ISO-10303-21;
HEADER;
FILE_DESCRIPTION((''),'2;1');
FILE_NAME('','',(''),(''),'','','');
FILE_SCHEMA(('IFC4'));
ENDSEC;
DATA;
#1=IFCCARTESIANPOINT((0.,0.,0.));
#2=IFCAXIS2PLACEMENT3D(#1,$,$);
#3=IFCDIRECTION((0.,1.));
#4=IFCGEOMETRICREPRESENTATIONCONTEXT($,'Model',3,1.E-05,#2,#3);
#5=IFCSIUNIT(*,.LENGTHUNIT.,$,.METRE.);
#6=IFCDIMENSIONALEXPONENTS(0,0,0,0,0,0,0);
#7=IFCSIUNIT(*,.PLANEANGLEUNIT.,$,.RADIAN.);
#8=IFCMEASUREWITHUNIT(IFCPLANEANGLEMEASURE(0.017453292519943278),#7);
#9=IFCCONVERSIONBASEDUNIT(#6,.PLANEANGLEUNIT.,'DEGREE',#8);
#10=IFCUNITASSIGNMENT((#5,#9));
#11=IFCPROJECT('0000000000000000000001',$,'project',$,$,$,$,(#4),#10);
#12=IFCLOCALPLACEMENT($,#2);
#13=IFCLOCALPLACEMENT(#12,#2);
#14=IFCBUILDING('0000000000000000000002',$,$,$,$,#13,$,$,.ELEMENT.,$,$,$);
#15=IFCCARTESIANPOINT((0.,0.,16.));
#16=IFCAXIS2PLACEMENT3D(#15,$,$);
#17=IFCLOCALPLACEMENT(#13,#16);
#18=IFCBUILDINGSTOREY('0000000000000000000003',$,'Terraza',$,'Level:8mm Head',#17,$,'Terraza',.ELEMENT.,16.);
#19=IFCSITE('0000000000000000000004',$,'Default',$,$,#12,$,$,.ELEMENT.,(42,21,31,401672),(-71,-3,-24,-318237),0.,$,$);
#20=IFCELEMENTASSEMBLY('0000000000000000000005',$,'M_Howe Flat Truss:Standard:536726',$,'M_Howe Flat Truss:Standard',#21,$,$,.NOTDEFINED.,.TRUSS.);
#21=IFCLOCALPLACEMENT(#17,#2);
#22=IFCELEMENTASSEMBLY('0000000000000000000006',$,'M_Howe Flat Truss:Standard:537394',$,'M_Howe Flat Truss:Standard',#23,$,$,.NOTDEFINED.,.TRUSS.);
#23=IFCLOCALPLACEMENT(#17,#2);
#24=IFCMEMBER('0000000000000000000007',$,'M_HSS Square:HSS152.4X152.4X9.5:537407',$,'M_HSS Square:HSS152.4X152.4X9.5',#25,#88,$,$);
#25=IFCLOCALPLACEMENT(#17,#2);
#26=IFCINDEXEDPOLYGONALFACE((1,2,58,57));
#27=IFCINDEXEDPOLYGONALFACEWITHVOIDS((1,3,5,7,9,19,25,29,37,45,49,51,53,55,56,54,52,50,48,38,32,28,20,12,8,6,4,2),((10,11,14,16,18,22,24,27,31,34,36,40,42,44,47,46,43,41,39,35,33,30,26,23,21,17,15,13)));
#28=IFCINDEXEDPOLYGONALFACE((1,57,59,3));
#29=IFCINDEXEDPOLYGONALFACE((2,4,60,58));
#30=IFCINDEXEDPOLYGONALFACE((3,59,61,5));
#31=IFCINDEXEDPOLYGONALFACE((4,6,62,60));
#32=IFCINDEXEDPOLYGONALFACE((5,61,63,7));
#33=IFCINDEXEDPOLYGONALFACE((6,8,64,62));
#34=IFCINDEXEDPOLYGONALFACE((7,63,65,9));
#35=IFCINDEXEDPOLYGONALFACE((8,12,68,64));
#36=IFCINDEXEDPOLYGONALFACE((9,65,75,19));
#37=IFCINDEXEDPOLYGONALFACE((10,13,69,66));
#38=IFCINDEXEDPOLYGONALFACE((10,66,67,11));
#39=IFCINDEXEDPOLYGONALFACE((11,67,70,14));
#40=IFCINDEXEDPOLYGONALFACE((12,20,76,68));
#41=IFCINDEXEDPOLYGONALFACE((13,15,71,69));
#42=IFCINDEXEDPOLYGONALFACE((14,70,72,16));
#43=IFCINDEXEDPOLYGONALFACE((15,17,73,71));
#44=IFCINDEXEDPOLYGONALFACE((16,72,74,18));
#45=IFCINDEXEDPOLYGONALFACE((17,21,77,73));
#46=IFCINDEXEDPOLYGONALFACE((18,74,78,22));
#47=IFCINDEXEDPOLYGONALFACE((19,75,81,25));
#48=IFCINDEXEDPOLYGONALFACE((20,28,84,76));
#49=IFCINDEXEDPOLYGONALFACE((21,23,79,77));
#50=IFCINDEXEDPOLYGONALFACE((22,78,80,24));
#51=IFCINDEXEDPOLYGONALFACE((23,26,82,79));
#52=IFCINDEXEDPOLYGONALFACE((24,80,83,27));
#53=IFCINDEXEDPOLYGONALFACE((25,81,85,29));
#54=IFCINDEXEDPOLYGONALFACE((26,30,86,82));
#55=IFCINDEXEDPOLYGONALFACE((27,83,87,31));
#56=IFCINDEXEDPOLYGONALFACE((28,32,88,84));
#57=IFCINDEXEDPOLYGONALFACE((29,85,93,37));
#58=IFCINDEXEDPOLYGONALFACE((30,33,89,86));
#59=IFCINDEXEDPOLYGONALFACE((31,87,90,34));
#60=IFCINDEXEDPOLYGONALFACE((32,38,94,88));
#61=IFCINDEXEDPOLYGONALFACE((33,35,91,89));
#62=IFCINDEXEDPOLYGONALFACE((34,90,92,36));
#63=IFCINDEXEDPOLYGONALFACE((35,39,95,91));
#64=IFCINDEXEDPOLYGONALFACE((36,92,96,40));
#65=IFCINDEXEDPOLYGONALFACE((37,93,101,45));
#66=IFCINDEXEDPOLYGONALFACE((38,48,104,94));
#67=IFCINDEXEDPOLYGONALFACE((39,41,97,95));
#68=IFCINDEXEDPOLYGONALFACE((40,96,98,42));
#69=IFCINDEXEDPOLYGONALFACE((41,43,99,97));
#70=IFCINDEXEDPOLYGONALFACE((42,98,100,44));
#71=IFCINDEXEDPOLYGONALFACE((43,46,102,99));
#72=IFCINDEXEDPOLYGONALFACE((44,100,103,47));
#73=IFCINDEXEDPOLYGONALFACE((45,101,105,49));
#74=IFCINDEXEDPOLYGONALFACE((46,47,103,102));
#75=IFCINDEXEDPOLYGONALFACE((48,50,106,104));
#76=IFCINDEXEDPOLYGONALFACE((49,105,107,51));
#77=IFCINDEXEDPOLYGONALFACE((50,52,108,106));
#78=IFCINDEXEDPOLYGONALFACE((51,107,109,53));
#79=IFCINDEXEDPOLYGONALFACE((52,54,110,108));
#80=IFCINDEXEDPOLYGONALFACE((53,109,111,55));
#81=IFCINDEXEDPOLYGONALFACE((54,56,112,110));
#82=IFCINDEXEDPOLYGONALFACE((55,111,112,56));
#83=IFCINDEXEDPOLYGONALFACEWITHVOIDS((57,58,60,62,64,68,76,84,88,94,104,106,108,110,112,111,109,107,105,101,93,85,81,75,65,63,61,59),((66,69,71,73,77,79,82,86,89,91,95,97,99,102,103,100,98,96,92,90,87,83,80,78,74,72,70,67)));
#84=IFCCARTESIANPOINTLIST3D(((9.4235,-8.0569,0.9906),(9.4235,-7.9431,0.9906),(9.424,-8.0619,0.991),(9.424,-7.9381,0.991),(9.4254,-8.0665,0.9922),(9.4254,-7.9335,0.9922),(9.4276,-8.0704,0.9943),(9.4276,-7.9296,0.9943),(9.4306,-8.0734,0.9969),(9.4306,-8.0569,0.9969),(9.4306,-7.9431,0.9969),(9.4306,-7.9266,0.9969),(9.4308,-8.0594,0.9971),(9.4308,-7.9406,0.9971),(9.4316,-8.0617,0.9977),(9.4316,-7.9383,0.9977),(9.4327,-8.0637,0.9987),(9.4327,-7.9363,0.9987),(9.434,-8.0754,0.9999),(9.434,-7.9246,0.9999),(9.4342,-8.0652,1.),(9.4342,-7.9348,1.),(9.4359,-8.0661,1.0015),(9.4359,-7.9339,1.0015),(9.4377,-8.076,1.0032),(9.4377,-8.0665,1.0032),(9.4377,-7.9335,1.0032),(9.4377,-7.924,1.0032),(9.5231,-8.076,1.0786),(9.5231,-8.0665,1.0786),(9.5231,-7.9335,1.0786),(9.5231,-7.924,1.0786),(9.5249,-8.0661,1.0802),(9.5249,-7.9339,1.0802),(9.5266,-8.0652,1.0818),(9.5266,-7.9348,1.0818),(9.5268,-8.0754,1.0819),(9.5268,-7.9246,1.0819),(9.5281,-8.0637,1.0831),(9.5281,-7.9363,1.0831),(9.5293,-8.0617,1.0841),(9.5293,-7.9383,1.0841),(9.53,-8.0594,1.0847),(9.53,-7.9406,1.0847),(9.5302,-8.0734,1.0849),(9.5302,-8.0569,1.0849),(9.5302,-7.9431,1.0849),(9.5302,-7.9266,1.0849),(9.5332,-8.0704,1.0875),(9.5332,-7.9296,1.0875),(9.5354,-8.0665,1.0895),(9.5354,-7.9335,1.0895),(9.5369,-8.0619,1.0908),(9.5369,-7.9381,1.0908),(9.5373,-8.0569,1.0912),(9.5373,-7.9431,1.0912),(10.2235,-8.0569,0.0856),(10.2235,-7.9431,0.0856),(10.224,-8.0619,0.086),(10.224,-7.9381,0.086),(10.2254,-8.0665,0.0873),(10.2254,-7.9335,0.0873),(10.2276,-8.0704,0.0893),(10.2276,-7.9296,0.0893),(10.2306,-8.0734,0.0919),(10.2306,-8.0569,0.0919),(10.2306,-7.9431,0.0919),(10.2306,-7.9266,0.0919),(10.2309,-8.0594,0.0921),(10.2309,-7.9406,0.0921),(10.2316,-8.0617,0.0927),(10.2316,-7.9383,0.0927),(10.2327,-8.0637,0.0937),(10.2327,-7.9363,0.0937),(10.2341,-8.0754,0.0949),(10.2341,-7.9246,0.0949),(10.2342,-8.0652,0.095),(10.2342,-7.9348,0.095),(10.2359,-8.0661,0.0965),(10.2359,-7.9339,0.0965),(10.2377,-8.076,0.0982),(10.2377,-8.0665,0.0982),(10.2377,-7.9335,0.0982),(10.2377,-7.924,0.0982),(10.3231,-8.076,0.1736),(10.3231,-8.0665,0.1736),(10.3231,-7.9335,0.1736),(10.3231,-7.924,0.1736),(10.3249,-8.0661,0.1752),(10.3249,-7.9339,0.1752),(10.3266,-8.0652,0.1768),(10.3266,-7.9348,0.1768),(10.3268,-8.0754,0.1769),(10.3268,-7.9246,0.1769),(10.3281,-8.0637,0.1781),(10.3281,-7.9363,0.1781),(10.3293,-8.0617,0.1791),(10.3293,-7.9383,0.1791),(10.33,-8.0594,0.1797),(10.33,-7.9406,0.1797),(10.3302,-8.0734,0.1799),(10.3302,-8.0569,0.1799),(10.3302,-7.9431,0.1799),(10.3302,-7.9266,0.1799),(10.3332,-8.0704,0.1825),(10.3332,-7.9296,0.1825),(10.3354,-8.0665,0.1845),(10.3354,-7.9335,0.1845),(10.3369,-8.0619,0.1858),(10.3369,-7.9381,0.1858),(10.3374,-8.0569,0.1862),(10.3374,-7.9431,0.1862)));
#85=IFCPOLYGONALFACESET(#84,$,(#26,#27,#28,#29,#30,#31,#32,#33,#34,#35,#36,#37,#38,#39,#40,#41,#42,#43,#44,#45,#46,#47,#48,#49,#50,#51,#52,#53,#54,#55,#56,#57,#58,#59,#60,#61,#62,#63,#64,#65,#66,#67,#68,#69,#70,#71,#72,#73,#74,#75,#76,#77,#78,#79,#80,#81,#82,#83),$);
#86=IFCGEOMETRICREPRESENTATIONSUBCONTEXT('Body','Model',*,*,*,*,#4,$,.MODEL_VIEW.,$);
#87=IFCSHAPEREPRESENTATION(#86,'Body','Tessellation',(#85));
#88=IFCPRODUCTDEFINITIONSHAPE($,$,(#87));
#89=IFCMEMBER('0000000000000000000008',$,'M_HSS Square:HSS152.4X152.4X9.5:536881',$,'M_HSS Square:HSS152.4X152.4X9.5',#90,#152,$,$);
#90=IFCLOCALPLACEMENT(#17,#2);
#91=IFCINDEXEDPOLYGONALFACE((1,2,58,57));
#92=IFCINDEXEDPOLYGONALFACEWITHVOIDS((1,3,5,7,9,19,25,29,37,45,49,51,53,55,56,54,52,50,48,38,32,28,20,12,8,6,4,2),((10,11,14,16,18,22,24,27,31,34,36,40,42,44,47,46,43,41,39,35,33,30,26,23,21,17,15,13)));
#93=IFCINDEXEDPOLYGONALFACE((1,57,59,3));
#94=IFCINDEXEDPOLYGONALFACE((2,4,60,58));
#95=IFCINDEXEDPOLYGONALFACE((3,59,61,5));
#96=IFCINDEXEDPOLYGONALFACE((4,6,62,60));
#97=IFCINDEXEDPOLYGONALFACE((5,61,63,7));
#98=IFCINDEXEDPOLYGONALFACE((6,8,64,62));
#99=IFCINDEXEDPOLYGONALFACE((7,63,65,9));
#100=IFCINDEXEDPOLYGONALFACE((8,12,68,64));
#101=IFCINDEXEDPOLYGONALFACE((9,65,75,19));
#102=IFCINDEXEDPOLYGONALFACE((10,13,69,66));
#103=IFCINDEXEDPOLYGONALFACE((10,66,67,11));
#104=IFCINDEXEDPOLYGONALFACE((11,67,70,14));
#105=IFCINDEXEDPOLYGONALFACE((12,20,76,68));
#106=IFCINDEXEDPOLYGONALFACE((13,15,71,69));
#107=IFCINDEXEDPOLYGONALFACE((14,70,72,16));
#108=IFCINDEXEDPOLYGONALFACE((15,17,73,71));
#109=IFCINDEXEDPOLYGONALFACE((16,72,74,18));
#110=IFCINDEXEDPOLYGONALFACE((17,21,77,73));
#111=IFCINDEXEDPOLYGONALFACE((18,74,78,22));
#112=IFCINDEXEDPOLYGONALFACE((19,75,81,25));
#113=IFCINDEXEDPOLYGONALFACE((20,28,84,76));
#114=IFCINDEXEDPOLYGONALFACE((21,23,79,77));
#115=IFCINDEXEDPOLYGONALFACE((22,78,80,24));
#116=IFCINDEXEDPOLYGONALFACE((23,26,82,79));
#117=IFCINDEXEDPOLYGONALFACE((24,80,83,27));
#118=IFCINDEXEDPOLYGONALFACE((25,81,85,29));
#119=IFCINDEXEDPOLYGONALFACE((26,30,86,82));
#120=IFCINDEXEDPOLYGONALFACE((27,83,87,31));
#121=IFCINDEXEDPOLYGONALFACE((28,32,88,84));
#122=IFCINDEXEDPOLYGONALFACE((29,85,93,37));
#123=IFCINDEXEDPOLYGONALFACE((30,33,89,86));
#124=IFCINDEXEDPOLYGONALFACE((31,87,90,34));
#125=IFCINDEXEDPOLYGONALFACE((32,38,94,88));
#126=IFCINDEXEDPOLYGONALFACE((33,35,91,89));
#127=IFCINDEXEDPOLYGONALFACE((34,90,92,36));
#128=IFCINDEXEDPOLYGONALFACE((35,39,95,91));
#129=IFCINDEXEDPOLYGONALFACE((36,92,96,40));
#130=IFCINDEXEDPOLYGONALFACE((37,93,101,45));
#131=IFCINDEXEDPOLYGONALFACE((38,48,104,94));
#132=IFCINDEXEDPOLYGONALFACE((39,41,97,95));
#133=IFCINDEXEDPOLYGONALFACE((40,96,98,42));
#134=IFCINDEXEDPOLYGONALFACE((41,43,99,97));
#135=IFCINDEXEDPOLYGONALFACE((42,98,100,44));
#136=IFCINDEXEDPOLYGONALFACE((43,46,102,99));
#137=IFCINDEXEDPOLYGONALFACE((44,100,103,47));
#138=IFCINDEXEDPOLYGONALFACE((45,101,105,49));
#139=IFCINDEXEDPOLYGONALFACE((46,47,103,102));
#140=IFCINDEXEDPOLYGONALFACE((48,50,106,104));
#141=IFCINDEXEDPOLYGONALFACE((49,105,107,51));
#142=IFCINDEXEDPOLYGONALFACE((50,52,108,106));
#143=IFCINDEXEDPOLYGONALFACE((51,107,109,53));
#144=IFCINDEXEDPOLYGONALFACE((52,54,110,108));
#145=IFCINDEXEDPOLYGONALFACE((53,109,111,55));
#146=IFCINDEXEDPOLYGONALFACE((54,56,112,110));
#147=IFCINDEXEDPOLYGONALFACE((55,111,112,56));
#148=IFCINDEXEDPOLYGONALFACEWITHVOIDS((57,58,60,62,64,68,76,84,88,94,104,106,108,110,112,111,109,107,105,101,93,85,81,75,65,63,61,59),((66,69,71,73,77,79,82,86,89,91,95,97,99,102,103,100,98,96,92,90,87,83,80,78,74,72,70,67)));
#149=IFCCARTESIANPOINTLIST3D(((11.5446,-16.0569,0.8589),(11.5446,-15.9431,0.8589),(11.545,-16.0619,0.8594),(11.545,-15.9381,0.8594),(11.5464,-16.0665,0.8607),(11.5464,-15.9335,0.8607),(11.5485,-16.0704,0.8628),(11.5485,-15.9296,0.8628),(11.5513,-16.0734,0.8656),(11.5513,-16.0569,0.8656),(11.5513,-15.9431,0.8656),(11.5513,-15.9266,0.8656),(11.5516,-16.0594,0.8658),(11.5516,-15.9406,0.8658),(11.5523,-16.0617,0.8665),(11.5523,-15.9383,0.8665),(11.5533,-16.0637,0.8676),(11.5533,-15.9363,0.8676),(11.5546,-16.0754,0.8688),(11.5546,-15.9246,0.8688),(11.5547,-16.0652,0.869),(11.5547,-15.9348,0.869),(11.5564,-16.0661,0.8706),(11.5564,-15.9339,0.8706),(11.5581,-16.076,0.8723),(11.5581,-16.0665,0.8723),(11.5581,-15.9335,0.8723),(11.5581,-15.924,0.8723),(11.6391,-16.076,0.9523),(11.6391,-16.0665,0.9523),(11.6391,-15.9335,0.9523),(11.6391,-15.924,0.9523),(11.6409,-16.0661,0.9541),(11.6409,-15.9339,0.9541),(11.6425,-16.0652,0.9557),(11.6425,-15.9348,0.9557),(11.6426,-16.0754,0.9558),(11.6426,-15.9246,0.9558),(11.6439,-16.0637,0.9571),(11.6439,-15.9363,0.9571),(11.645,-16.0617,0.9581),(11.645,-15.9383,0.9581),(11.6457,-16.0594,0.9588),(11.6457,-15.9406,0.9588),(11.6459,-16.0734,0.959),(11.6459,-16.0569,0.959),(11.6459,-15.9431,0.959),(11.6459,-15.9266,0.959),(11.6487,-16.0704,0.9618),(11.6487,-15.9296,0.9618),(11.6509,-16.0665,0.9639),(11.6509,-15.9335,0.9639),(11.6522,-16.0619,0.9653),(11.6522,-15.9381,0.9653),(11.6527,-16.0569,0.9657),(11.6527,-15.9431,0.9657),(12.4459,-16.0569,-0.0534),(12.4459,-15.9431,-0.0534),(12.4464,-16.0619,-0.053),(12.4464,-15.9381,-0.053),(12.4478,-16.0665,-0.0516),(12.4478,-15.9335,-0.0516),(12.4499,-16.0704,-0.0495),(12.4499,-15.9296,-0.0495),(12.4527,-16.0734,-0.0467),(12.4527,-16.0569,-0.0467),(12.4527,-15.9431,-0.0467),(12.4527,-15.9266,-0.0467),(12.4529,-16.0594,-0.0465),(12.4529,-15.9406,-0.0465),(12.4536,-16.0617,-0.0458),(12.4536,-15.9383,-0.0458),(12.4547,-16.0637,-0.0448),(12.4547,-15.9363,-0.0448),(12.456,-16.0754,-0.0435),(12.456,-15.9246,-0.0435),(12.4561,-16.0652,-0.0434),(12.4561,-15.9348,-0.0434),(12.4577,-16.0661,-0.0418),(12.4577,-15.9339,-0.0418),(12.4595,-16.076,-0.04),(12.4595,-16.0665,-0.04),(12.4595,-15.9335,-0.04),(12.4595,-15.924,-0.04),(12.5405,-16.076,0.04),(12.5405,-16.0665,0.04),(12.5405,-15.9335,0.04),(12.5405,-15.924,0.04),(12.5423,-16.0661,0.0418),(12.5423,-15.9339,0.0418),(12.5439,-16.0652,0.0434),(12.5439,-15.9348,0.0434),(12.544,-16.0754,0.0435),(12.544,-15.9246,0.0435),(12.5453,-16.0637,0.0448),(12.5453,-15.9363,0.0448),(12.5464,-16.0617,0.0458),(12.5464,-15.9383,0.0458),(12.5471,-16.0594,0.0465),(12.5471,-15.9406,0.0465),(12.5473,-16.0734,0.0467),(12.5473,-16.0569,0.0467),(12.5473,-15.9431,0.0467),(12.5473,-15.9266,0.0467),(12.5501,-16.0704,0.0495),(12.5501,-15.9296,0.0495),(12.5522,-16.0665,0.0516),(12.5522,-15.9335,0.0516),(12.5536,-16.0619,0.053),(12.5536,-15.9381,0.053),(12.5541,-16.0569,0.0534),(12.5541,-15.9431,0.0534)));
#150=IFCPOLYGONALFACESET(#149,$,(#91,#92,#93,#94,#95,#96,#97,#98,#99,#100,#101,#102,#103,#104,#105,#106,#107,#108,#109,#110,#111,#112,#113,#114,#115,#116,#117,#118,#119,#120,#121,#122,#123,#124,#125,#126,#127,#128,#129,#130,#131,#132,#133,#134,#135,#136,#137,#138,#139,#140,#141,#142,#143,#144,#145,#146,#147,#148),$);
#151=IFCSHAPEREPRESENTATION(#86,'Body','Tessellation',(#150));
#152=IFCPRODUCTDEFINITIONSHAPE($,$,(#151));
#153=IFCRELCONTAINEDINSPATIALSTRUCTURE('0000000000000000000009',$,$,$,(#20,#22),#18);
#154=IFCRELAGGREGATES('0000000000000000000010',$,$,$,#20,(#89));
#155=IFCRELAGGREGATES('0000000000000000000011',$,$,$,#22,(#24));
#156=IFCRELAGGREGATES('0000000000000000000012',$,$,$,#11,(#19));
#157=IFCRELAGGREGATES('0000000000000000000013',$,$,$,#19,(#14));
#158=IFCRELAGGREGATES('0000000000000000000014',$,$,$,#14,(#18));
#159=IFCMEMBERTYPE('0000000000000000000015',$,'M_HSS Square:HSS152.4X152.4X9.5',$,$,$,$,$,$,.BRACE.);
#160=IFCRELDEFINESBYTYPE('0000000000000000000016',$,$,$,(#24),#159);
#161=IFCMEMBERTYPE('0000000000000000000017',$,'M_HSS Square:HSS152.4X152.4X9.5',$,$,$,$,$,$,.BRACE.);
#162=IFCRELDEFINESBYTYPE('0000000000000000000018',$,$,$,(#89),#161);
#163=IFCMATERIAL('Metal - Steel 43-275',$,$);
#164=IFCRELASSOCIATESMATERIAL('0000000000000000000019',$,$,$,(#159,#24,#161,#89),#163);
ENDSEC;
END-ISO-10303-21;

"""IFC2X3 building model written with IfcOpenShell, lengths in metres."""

from ifc_helpers import new_model, entity, si_unit, converted_unit, direction, frame, frame_2d, origin, place, context, subcontext, project, spatial, polyline, circle_curve, parameter, trimmed, segment, composite_curve, outline, extrude, source, transform, mapped, material, type_object, type_shapes, element, aggregate, save


model = new_model("IFC2X3")

# Units and contexts
model_context = context("Model", 3, precision=1e-05, world=origin(), true_north=direction((0.0, 1.0)))
body_context = subcontext(model_context, "Body", "Model", "MODEL_VIEW")
ifc_project = project(units=[si_unit("LENGTHUNIT", "METRE"), converted_unit("PLANEANGLEUNIT", "DEGREE", entity("IfcPlaneAngleMeasure", 0.017453292519943278), si_unit("PLANEANGLEUNIT", "RADIAN"), dimensions=[0, 0, 0, 0, 0, 0, 0])], contexts=[model_context])

# Site, building, storey
site_placement = place(None, origin())
site = spatial("IfcSite", under=ifc_project, at=site_placement, Name="Default", CompositionType="ELEMENT", RefLatitude=(42, 21, 31, 401672), RefLongitude=(-71, -3, -24, -318237), RefElevation=0.0)
building_placement = place(site_placement, origin())
building = spatial("IfcBuilding", under=site, at=building_placement, CompositionType="ELEMENT")
storey_placement = place(building_placement, frame((0.0, 0.0, 16.0)))
storey = spatial("IfcBuildingStorey", under=building, at=storey_placement, Name="Terraza", ObjectType="Level:8mm Head", LongName="Terraza", CompositionType="ELEMENT", Elevation=16.0)

# Element assemblies
assembly_1_placement = place(storey_placement, origin())
assembly_1 = element("IfcElementAssembly", 1, at=assembly_1_placement, inside=storey, Name="M_Howe Flat Truss:Standard:536726", ObjectType="M_Howe Flat Truss:Standard", AssemblyPlace="NOTDEFINED", PredefinedType="TRUSS")
ifc_material = material(Name="Metal - Steel 43-275")
assembly_2_placement = place(storey_placement, origin())
assembly_2 = element("IfcElementAssembly", 2, at=assembly_2_placement, inside=storey, Name="M_Howe Flat Truss:Standard:537394", ObjectType="M_Howe Flat Truss:Standard", AssemblyPlace="NOTDEFINED", PredefinedType="TRUSS")

# Members
member_type_1 = type_object("IfcMemberType", Name="M_HSS Square:HSS152.4X152.4X9.5", PredefinedType="BRACE", material=ifc_material)
shared_shape_1 = source(origin(), body_context, "Body", "SweptSolid", [
    extrude(outline(composite_curve([segment(polyline([(-0.0569, -0.076), (0.0569, -0.076)]), True, "CONTINUOUS"), segment(trimmed(circle_curve(frame_2d((0.0569, -0.0569), x_axis=(0.0, 1.0)), 0.0191), [parameter(180.0)], [parameter(270.0)], True, "PARAMETER"), True, "CONTINUOUS"), segment(polyline([(0.076, -0.0569), (0.076, 0.0569)]), True, "CONTINUOUS"), segment(trimmed(circle_curve(frame_2d((0.0569, 0.0569), x_axis=(0.0, 1.0)), 0.0191), [parameter(270.0)], [parameter(0.0)], True, "PARAMETER"), True, "CONTINUOUS"), segment(polyline([(0.0569, 0.076), (-0.0569, 0.076)]), True, "CONTINUOUS"), segment(trimmed(circle_curve(frame_2d((-0.0569, 0.0569), x_axis=(0.0, 1.0)), 0.0191), [parameter(0.0)], [parameter(90.0)], True, "PARAMETER"), True, "CONTINUOUS"), segment(polyline([(-0.076, 0.0569), (-0.076, -0.0569)]), True, "CONTINUOUS"), segment(trimmed(circle_curve(frame_2d((-0.0569, -0.0569), x_axis=(0.0, 1.0)), 0.0191), [parameter(90.0)], [parameter(180.0)], True, "PARAMETER"), True, "CONTINUOUS")], self_intersect=False), holes=[composite_curve([segment(trimmed(circle_curve(frame_2d((-0.0569, 0.0569), x_axis=(0.0, 1.0)), 0.0095), [parameter(360.0)], [parameter(90.0)], True, "PARAMETER"), False, "CONTINUOUS"), segment(polyline([(-0.0569, 0.0665), (0.0569, 0.0665)]), True, "CONTINUOUS"), segment(trimmed(circle_curve(frame_2d((0.0569, 0.0569), x_axis=(0.0, 1.0)), 0.0095), [parameter(270.0)], [parameter(360.0)], True, "PARAMETER"), False, "CONTINUOUS"), segment(polyline([(0.0665, 0.0569), (0.0665, -0.0569)]), True, "CONTINUOUS"), segment(trimmed(circle_curve(frame_2d((0.0569, -0.0569), x_axis=(0.0, 1.0)), 0.0095), [parameter(180.0)], [parameter(270.0)], True, "PARAMETER"), False, "CONTINUOUS"), segment(polyline([(0.0569, -0.0665), (-0.0569, -0.0665)]), True, "CONTINUOUS"), segment(trimmed(circle_curve(frame_2d((-0.0569, -0.0569), x_axis=(0.0, 1.0)), 0.0095), [parameter(90.0)], [parameter(180.0)], True, "PARAMETER"), False, "CONTINUOUS"), segment(polyline([(-0.0665, -0.0569), (-0.0665, 0.0569)]), True, "CONTINUOUS")], self_intersect=False)]), frame((-0.5968, 0.0, 0.0), z_axis=(1.0, 0.0, 0.0), x_axis=(0.0, 0.0, -1.0)), (0.0, 0.0, 1.0), 1.2079),
])
type_shapes(member_type_1, [shared_shape_1])
member_1_placement = place(assembly_2_placement, frame((9.8757, -8.0, 0.5937), z_axis=(-0.749231, 0.0, -0.662309), x_axis=(0.662309, 0.0, -0.749231)))
member_1 = element("IfcMember", 3, at=member_1_placement, type_object=member_type_1, material=ifc_material, Name="M_HSS Square:HSS152.4X152.4X9.5:537407", ObjectType="M_HSS Square:HSS152.4X152.4X9.5", context=body_context, shape_type="MappedRepresentation", body=[
    mapped(shared_shape_1, transform((0.0, 0.0, 0.0), scale=1.0)),
])
member_type_2 = type_object("IfcMemberType", Name="M_HSS Square:HSS152.4X152.4X9.5", PredefinedType="BRACE", material=ifc_material)
shared_shape_2 = source(origin(), body_context, "Body", "SweptSolid", [
    extrude(outline(composite_curve([segment(polyline([(-0.0569, -0.076), (0.0569, -0.076)]), True, "CONTINUOUS"), segment(trimmed(circle_curve(frame_2d((0.0569, -0.0569), x_axis=(0.0, 1.0)), 0.0191), [parameter(180.0)], [parameter(270.0)], True, "PARAMETER"), True, "CONTINUOUS"), segment(polyline([(0.076, -0.0569), (0.076, 0.0569)]), True, "CONTINUOUS"), segment(trimmed(circle_curve(frame_2d((0.0569, 0.0569), x_axis=(0.0, 1.0)), 0.0191), [parameter(270.0)], [parameter(0.0)], True, "PARAMETER"), True, "CONTINUOUS"), segment(polyline([(0.0569, 0.076), (-0.0569, 0.076)]), True, "CONTINUOUS"), segment(trimmed(circle_curve(frame_2d((-0.0569, 0.0569), x_axis=(0.0, 1.0)), 0.0191), [parameter(0.0)], [parameter(90.0)], True, "PARAMETER"), True, "CONTINUOUS"), segment(polyline([(-0.076, 0.0569), (-0.076, -0.0569)]), True, "CONTINUOUS"), segment(trimmed(circle_curve(frame_2d((-0.0569, -0.0569), x_axis=(0.0, 1.0)), 0.0191), [parameter(90.0)], [parameter(180.0)], True, "PARAMETER"), True, "CONTINUOUS")], self_intersect=False), holes=[composite_curve([segment(trimmed(circle_curve(frame_2d((-0.0569, 0.0569), x_axis=(0.0, 1.0)), 0.0095), [parameter(360.0)], [parameter(90.0)], True, "PARAMETER"), False, "CONTINUOUS"), segment(polyline([(-0.0569, 0.0665), (0.0569, 0.0665)]), True, "CONTINUOUS"), segment(trimmed(circle_curve(frame_2d((0.0569, 0.0569), x_axis=(0.0, 1.0)), 0.0095), [parameter(270.0)], [parameter(360.0)], True, "PARAMETER"), False, "CONTINUOUS"), segment(polyline([(0.0665, 0.0569), (0.0665, -0.0569)]), True, "CONTINUOUS"), segment(trimmed(circle_curve(frame_2d((0.0569, -0.0569), x_axis=(0.0, 1.0)), 0.0095), [parameter(180.0)], [parameter(270.0)], True, "PARAMETER"), False, "CONTINUOUS"), segment(polyline([(0.0569, -0.0665), (-0.0569, -0.0665)]), True, "CONTINUOUS"), segment(trimmed(circle_curve(frame_2d((-0.0569, -0.0569), x_axis=(0.0, 1.0)), 0.0095), [parameter(90.0)], [parameter(180.0)], True, "PARAMETER"), False, "CONTINUOUS"), segment(polyline([(-0.0665, -0.0569), (-0.0665, 0.0569)]), True, "CONTINUOUS")], self_intersect=False)]), frame((-0.5357, 0.0, 0.0), z_axis=(1.0, 0.0, 0.0), x_axis=(0.0, 0.0, -1.0)), (0.0, 0.0, 1.0), 1.2825),
])
type_shapes(member_type_2, [shared_shape_2])
member_2_placement = place(assembly_1_placement, frame((11.9751, -16.0, 0.5312), z_axis=(-0.711368, 0.0, -0.702819), x_axis=(0.702819, 0.0, -0.711368)))
member_2 = element("IfcMember", 4, at=member_2_placement, type_object=member_type_2, material=ifc_material, Name="M_HSS Square:HSS152.4X152.4X9.5:536881", ObjectType="M_HSS Square:HSS152.4X152.4X9.5", context=body_context, shape_type="MappedRepresentation", body=[
    mapped(shared_shape_2, transform((0.0, 0.0, 0.0), scale=1.0)),
])
aggregate(assembly_1, [member_2])
aggregate(assembly_2, [member_1])

save(model, "model.ifc")
